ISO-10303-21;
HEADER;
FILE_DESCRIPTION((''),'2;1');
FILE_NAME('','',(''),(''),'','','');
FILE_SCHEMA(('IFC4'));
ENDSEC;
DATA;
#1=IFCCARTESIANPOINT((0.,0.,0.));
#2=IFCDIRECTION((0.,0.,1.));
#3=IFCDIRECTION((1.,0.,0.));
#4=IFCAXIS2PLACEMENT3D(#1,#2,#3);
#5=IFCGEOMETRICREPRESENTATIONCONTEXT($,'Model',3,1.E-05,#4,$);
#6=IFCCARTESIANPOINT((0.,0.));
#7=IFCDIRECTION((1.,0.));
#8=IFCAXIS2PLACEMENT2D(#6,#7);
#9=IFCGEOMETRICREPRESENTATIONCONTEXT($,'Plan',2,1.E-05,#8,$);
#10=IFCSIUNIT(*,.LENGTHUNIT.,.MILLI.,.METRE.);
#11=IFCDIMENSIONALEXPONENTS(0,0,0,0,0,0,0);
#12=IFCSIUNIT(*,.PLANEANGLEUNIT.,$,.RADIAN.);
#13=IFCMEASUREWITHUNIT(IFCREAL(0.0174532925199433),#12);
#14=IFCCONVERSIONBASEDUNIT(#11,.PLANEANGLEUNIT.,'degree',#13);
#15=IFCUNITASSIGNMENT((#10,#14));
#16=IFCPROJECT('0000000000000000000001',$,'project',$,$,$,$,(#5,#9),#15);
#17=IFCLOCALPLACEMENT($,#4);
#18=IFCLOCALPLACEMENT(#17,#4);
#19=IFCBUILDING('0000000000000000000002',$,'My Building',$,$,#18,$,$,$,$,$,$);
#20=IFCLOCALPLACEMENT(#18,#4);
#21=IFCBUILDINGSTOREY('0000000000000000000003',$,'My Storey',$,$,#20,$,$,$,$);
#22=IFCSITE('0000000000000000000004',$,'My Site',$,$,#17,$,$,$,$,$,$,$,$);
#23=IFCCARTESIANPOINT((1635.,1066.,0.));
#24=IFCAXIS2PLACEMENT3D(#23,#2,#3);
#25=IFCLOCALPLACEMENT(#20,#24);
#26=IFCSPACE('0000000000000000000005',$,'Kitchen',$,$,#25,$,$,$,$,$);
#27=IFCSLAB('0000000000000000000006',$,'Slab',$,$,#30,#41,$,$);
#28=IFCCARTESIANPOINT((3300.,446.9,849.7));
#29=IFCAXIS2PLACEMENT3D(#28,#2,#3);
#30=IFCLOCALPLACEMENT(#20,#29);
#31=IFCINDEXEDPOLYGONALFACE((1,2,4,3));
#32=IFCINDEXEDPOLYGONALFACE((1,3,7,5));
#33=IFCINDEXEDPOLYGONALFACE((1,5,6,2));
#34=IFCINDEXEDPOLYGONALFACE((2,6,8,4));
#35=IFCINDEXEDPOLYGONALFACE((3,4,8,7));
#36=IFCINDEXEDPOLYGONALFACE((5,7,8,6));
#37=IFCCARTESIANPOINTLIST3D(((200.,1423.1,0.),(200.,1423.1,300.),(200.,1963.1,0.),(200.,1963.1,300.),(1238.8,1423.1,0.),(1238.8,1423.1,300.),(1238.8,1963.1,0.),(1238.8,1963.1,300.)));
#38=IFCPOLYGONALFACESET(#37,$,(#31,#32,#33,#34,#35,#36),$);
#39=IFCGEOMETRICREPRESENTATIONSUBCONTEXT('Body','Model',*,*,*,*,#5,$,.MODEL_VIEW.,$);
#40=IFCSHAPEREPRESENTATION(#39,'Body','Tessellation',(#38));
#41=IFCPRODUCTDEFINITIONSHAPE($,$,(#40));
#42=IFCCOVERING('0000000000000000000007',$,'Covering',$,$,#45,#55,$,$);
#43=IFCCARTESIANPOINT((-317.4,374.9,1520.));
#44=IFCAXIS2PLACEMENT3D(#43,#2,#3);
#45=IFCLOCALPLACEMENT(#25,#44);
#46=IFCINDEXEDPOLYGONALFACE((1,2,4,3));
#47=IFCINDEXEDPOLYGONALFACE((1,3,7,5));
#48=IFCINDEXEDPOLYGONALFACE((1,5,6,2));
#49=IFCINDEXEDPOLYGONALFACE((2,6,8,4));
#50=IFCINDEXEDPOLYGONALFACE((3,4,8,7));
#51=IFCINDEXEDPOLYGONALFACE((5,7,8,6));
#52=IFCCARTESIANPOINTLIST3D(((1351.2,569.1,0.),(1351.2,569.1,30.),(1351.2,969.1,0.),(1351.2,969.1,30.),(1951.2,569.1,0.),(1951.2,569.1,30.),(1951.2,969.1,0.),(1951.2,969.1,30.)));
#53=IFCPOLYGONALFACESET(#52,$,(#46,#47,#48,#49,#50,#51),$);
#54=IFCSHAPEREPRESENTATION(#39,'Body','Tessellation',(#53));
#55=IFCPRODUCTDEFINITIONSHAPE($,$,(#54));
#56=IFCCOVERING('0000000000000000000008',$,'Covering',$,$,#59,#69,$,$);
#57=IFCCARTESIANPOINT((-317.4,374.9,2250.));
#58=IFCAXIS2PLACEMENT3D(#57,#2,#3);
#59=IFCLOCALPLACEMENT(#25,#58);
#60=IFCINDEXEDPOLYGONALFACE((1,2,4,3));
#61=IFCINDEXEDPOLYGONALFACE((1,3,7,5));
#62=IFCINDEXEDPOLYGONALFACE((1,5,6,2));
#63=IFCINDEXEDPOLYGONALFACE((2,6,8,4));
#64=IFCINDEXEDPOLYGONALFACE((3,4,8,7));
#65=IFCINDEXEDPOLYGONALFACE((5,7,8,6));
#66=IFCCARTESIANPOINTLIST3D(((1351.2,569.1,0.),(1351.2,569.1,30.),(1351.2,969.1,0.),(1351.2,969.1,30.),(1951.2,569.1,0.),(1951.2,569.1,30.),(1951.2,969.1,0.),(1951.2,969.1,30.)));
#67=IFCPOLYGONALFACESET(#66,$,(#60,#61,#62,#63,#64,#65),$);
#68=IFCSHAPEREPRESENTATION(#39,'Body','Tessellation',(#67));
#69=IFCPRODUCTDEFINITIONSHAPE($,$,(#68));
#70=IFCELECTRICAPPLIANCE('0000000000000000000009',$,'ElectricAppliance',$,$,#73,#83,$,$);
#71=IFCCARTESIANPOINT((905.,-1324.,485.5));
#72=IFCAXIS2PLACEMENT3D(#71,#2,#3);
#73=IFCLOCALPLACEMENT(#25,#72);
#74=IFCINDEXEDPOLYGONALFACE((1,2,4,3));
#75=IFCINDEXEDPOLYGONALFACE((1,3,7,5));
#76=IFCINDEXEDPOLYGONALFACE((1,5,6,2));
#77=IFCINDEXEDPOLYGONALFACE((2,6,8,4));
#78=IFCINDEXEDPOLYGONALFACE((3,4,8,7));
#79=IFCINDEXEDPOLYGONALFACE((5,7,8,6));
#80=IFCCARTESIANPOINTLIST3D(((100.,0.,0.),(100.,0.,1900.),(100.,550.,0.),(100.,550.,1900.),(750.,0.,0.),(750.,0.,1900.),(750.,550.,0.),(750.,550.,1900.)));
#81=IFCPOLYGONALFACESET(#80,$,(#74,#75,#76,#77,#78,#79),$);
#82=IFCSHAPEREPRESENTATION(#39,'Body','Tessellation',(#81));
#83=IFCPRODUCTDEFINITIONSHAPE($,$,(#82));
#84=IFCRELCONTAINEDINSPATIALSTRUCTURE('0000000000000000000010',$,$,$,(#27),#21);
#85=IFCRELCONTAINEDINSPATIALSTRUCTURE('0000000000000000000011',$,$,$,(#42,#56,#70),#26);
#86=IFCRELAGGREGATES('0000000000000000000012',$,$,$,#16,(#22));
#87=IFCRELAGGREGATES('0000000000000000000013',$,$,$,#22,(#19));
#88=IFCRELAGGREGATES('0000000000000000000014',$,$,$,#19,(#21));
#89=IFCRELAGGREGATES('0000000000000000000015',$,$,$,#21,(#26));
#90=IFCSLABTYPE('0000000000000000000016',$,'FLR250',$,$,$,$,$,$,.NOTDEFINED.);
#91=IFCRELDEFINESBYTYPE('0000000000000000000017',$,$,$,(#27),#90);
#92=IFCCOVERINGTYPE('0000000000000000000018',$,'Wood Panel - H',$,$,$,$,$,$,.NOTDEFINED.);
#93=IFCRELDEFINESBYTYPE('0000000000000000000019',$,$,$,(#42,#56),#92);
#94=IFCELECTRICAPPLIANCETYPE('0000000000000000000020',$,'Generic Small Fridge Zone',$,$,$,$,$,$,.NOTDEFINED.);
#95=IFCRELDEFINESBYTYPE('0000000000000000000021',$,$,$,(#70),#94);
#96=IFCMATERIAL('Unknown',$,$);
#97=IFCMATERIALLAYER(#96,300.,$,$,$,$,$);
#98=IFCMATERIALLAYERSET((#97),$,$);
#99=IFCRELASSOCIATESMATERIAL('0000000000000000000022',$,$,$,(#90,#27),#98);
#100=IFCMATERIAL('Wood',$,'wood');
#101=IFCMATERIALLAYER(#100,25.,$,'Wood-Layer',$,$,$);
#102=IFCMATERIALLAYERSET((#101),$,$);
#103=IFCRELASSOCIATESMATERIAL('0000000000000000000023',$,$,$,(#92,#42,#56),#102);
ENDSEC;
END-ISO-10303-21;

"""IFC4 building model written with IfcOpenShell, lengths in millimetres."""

from ifc_helpers import new_model, entity, si_unit, converted_unit, frame, origin_with_axes, origin_2d_with_axis, place, context, subcontext, project, spatial, line, indexed_curve, outline, extrude, shape, source, transform, mapped, material, layer, layer_set, layer_usage, type_object, type_shapes, element, save


model = new_model("IFC4")

# Units and contexts
model_context = context("Model", 3, precision=1e-05, world=origin_with_axes())
plan_context = context("Plan", 2, precision=1e-05, world=origin_2d_with_axis())
body_context_1 = subcontext(model_context, "Body", "Model", "MODEL_VIEW")
body_context_2 = subcontext(plan_context, "Body", "Plan", "PLAN_VIEW")
ifc_project = project(units=[si_unit("LENGTHUNIT", "METRE", prefix="MILLI"), converted_unit("PLANEANGLEUNIT", "degree", entity("IfcReal", 0.0174532925199433), si_unit("PLANEANGLEUNIT", "RADIAN"), dimensions=[0, 0, 0, 0, 0, 0, 0])], contexts=[model_context, plan_context])

# Site, building, storey
site_placement = place(None, origin_with_axes())
site = spatial("IfcSite", under=ifc_project, at=site_placement, Name="My Site")
building_placement = place(site_placement, origin_with_axes())
building = spatial("IfcBuilding", under=site, at=building_placement, Name="My Building")
storey_placement = place(building_placement, origin_with_axes())
storey = spatial("IfcBuildingStorey", under=building, at=storey_placement, Name="My Storey")

# Slab
ifc_material_1 = material(Name="Unknown")
ifc_layer_1 = layer(ifc_material_1, 300.0)
ifc_layer_set_1 = layer_set([ifc_layer_1])
ifc_layer_usage_1 = layer_usage(ifc_layer_set_1, "AXIS3", "POSITIVE", 0.0)
slab_type = type_object("IfcSlabType", Name="FLR250", PredefinedType="NOTDEFINED", material=ifc_layer_set_1)
slab_placement = place(storey_placement, frame((3300.0, 446.9, 849.7), z_axis=(0.0, 0.0, 1.0), x_axis=(1.0, 0.0, 0.0)))
element("IfcSlab", 1, at=slab_placement, inside=storey, type_object=slab_type, material=ifc_layer_usage_1, Name="Slab", context=body_context_1, shape_type="SweptSolid", body=[
    extrude(outline(indexed_curve([(200.0, 1963.1), (200.0, 1423.1), (1238.8, 1423.1), (1238.8, 1963.1)], segments=[line(3, 2), line(2, 1), line(1, 4), line(4, 3)], self_intersect=False)), None, (0.0, 0.0, 1.0), 300.0),
])

# Shared definitions
space_1_placement = place(storey_placement, frame((1635.0, 1066.0, 0.0), z_axis=(0.0, 0.0, 1.0), x_axis=(1.0, 0.0, 0.0)))
space_1 = spatial("IfcSpace", under=storey, at=space_1_placement, Name="Kitchen")

# Shared definitions
ifc_material_2 = material(Name="Wood", Category="wood")

# Coverings
ifc_layer_2 = layer(ifc_material_2, 25.0, Name="Wood-Layer")
ifc_layer_set_2 = layer_set([ifc_layer_2])
ifc_layer_usage_2 = layer_usage(ifc_layer_set_2, "AXIS3", "POSITIVE", 0.0)
covering_type_1 = type_object("IfcCoveringType", Name="Wood Panel - H", PredefinedType="NOTDEFINED", material=ifc_layer_set_2)
covering_1_placement = place(space_1_placement, frame((-317.4, 374.9, 1520.0), z_axis=(0.0, 0.0, 1.0), x_axis=(1.0, 0.0, 0.0)))
element("IfcCovering", 2, at=covering_1_placement, inside=space_1, type_object=covering_type_1, material=ifc_layer_usage_2, Name="Covering", context=body_context_1, shape_type="SweptSolid", body=[
    extrude(outline(indexed_curve([(1351.2, 569.1), (1951.2, 569.1), (1951.2, 969.1), (1351.2, 969.1)], segments=[line(4, 1), line(1, 2), line(2, 3), line(3, 4)], self_intersect=False)), None, (0.0, 0.0, 1.0), 30.0),
])
ifc_layer_usage_3 = layer_usage(ifc_layer_set_2, "AXIS3", "POSITIVE", 0.0)
covering_2_placement = place(space_1_placement, frame((-317.4, 374.9, 2250.0), z_axis=(0.0, 0.0, 1.0), x_axis=(1.0, 0.0, 0.0)))
element("IfcCovering", 3, at=covering_2_placement, inside=space_1, type_object=covering_type_1, material=ifc_layer_usage_3, Name="Covering", context=body_context_1, shape_type="SweptSolid", body=[
    extrude(outline(indexed_curve([(1351.2, 569.1), (1951.2, 569.1), (1951.2, 969.1), (1351.2, 969.1)], segments=[line(3, 2), line(2, 1), line(1, 4), line(4, 3)], self_intersect=False)), None, (0.0, 0.0, 1.0), 30.0),
])

# Electric appliance
electric_appliance_type = type_object("IfcElectricApplianceType", Name="Generic Small Fridge Zone", PredefinedType="NOTDEFINED")
shared_shape_1 = source(origin_with_axes(), body_context_1, "Body", "SweptSolid", [
    extrude(outline(indexed_curve([(750.0, 550.0), (750.0, 0.0), (100.0, 0.0), (100.0, 550.0)], segments=[line(3, 2), line(2, 1), line(1, 4), line(4, 3)], self_intersect=False)), origin_with_axes(), (0.0, 0.0, 1.0), 1900.0),
])
shared_shape_2 = source(origin_with_axes(), body_context_2, "Body", "Curve2D", [
    entity("IfcIndexedPolyCurve", entity("IfcCartesianPointList2D", [[0.0, 0.0], [750.0, 0.0], [750.0, 650.0], [0.0, 650.0]]), [entity("IfcLineIndex", [1, 2, 3, 4, 1])]),
])
type_shapes(electric_appliance_type, [shared_shape_1, shared_shape_2])
electric_appliance_placement = place(space_1_placement, frame((905.0, -1324.0, 485.5), z_axis=(0.0, 0.0, 1.0), x_axis=(1.0, 0.0, 0.0)))
element("IfcElectricAppliance", 4, at=electric_appliance_placement, inside=space_1, type_object=electric_appliance_type, Name="ElectricAppliance", shapes=[
    shape(body_context_1, "Body", "MappedRepresentation", [mapped(shared_shape_1, transform((0.0, 0.0, 0.0), x_axis=(1.0, 0.0, 0.0), y_axis=(0.0, 1.0, 0.0), z_axis=(0.0, 0.0, 1.0), scale=1.0))]),
    shape(body_context_2, "Body", "MappedRepresentation", [mapped(shared_shape_2, transform((0.0, 0.0, 0.0), x_axis=(1.0, 0.0, 0.0), y_axis=(0.0, 1.0, 0.0), z_axis=(0.0, 0.0, 1.0), scale=1.0))]),
])

save(model, "model.ifc")
